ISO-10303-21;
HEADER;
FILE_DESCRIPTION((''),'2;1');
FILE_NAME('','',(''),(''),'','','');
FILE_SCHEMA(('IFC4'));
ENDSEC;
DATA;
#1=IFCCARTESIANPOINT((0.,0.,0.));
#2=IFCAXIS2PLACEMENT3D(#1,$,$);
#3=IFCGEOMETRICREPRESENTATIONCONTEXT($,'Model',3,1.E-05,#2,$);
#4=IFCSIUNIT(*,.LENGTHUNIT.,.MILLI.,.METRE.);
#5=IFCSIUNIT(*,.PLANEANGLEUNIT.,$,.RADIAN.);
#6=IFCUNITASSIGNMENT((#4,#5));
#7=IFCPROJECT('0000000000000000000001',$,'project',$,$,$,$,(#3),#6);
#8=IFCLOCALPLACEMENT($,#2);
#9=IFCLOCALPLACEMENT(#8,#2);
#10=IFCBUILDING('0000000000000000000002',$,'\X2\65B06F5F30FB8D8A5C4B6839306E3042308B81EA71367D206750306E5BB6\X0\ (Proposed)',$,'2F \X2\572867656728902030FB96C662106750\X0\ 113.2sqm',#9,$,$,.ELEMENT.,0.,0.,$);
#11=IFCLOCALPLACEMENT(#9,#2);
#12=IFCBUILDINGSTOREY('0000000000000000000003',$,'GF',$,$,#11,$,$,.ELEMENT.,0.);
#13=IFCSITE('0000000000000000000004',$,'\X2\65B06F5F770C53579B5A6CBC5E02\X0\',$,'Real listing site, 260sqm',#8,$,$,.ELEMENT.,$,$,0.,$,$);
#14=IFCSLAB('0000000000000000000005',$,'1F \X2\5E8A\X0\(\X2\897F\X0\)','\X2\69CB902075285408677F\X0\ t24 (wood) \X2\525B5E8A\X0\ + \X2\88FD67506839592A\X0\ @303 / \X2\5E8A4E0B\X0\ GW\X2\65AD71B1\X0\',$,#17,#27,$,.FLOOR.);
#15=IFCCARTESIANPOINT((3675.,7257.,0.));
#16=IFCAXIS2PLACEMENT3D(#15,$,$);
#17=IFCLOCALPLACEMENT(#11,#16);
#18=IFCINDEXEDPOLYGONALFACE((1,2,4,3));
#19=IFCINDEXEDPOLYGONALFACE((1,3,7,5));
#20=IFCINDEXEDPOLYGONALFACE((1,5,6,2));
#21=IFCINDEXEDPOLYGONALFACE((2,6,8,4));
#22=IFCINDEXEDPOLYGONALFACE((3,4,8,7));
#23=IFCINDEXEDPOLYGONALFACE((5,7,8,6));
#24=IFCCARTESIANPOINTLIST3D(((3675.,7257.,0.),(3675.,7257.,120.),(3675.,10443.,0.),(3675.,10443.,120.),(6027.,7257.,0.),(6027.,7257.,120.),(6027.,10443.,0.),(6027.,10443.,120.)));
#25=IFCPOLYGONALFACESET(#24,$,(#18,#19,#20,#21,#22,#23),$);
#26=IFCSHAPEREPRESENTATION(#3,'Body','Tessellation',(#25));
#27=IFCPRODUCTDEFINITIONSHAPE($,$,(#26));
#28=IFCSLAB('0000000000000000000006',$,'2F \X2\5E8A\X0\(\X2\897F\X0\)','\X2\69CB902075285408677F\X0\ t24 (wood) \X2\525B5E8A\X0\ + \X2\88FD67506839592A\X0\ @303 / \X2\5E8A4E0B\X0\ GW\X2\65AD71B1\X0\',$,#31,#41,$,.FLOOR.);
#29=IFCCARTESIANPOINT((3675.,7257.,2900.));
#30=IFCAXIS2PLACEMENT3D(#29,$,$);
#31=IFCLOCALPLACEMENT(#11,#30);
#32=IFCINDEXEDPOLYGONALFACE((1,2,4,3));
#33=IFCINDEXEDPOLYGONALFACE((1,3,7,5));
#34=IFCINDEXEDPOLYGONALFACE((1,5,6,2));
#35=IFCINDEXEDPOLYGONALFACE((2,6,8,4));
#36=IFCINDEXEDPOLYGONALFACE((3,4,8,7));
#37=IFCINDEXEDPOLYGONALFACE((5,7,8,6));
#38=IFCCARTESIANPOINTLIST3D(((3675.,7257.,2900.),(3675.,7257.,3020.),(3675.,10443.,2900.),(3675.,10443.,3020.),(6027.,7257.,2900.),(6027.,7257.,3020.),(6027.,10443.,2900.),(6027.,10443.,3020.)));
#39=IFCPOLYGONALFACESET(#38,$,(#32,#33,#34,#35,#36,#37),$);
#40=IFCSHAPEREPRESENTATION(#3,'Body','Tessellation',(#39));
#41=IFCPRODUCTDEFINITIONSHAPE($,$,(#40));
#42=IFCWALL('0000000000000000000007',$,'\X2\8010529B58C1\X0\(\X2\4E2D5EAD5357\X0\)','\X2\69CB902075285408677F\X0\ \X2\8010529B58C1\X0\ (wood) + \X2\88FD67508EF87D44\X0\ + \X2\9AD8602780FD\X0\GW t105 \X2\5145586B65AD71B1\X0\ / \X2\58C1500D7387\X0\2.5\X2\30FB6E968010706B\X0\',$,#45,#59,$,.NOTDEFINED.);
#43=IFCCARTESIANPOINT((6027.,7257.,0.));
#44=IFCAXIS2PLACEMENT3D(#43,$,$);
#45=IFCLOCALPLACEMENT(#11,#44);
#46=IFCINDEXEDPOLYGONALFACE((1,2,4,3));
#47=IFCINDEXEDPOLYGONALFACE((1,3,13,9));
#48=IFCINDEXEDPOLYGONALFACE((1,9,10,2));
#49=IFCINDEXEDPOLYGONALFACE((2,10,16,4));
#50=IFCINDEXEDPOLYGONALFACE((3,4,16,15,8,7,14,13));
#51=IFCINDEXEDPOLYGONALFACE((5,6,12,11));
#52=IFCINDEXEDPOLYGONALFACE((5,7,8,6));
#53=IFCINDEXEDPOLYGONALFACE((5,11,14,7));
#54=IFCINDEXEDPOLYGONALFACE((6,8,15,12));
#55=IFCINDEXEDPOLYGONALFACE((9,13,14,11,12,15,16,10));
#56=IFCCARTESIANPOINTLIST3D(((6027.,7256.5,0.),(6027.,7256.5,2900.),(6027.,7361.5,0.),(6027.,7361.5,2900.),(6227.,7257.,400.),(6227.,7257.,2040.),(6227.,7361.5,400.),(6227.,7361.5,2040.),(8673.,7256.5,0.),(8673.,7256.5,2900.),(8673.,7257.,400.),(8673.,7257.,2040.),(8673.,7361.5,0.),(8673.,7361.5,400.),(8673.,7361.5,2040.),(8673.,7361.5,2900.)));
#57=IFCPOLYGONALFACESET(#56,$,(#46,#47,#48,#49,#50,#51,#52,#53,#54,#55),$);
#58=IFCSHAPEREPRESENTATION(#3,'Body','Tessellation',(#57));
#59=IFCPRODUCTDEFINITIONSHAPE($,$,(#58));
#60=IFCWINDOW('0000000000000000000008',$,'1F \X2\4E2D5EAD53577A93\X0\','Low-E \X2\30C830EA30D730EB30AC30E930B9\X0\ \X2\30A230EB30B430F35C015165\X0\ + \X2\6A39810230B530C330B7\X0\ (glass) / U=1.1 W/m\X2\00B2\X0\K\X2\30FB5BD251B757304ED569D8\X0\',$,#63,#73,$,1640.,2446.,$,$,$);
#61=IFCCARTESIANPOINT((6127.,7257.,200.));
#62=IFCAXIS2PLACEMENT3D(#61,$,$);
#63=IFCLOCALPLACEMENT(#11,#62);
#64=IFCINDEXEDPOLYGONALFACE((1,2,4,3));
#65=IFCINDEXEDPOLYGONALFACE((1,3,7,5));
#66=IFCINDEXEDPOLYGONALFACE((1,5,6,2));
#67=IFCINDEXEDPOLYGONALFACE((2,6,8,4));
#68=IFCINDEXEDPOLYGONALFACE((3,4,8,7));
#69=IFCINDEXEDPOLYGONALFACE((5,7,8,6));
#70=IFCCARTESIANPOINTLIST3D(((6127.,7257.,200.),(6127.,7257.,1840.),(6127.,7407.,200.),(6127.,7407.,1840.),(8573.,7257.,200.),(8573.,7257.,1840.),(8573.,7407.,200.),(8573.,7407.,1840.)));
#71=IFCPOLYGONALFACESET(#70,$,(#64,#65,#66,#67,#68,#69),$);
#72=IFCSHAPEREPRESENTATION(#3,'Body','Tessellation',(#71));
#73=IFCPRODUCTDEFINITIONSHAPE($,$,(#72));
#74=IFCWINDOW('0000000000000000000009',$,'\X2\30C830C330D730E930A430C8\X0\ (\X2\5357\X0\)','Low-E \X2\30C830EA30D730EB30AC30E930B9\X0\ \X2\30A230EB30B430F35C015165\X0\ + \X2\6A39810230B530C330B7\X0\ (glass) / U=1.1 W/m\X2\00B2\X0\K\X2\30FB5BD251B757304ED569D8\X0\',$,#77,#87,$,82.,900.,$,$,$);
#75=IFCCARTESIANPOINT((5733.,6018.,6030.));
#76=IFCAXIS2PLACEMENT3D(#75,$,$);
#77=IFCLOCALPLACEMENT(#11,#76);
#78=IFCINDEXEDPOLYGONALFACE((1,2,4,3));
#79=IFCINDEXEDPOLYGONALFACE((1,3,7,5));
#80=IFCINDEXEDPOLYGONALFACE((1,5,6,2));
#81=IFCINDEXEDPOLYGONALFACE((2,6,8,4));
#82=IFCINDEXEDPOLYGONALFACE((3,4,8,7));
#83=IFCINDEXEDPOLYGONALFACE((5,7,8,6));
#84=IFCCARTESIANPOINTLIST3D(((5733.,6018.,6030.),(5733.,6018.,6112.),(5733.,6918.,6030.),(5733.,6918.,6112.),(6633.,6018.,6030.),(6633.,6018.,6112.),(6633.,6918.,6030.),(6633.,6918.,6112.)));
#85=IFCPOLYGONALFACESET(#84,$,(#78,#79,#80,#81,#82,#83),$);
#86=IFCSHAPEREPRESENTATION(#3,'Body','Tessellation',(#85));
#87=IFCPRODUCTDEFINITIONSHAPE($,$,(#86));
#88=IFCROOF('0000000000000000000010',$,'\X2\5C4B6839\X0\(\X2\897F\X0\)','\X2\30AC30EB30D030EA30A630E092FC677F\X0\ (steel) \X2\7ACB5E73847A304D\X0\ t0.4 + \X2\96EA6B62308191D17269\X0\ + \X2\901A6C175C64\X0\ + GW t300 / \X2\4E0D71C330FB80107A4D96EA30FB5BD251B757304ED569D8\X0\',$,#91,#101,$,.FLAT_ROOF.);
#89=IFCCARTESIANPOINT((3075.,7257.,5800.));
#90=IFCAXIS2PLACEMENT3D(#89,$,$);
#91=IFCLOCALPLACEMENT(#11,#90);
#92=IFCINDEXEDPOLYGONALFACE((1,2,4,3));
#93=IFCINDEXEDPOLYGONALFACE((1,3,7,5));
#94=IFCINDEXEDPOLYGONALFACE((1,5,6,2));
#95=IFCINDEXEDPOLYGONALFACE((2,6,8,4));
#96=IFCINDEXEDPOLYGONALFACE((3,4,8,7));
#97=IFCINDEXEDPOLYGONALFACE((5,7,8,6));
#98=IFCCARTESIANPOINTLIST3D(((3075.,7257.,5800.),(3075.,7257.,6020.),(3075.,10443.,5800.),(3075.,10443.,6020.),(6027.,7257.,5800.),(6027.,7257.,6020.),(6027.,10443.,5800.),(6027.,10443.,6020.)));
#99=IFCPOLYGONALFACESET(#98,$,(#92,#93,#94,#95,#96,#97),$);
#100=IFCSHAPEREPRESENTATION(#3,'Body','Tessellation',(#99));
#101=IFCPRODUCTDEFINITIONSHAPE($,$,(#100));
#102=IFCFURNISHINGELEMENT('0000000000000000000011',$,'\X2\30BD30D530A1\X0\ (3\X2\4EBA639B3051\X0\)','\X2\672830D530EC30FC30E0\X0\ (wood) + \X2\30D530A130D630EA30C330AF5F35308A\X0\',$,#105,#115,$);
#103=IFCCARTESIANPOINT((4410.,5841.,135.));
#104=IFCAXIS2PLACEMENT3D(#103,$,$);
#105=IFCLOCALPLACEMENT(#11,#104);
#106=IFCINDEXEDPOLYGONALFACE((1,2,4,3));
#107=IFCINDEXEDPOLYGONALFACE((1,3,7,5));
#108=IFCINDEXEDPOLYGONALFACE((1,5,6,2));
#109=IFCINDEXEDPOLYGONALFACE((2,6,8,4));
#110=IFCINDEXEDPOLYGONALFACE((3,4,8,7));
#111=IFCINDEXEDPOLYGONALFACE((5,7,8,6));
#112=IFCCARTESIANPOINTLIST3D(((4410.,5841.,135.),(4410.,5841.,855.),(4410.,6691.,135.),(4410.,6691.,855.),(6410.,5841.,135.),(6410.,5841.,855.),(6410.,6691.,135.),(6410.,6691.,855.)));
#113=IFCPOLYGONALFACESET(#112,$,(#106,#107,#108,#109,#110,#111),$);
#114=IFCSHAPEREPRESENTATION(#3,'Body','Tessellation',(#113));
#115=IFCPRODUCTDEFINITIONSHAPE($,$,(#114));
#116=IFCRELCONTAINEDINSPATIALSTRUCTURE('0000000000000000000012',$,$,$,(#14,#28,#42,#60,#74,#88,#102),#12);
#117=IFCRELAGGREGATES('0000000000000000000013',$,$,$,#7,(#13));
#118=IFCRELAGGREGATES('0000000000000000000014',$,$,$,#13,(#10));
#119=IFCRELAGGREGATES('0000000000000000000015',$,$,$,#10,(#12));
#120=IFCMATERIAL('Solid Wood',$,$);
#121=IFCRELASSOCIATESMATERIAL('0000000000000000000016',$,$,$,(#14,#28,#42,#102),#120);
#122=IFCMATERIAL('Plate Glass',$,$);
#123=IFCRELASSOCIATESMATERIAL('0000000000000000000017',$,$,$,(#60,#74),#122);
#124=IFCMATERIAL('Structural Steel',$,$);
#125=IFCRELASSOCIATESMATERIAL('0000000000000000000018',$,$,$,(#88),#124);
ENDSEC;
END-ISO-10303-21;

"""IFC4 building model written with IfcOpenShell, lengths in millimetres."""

from ifc_helpers import new_model, si_unit, frame, frame_2d, origin, place, context, project, spatial, rectangle, extrude, material, element, fill, save


model = new_model("IFC4")

# Units and contexts
model_context = context("Model", 3, precision=1e-05, world=origin())
ifc_project = project(units=[si_unit("LENGTHUNIT", "METRE", prefix="MILLI"), si_unit("PLANEANGLEUNIT", "RADIAN")], contexts=[model_context])

# Site, building, storey
site_placement = place(None, origin())
site = spatial("IfcSite", under=ifc_project, at=site_placement, Name="新潟県南魚沼市", ObjectType="Real listing site, 260sqm", CompositionType="ELEMENT", RefElevation=0.0)
building_placement = place(site_placement, origin())
building = spatial("IfcBuilding", under=site, at=building_placement, Name="新潟・越屋根のある自然素材の家 (Proposed)", ObjectType="2F 在来木造・集成材 113.2sqm", CompositionType="ELEMENT", ElevationOfRefHeight=0.0, ElevationOfTerrain=0.0)
storey_placement = place(building_placement, origin())
storey = spatial("IfcBuildingStorey", under=building, at=storey_placement, Name="GF", CompositionType="ELEMENT", Elevation=0.0)

# Shared definitions
ifc_material_1 = material(Name="Solid Wood")

# Slabs
slab_1_placement = place(storey_placement, frame((3675.0, 7257.0, 0.0)))
element("IfcSlab", 1, at=slab_1_placement, inside=storey, material=ifc_material_1, Name="1F 床(西)", Description="構造用合板 t24 (wood) 剛床 + 製材根太 @303 / 床下 GW断熱", PredefinedType="FLOOR", context=model_context, shape_type="SweptSolid", body=[
    extrude(rectangle(XDim=2352.0, YDim=3186.0, at=frame_2d((1176.0, 1593.0))), frame((3675.0, 7257.0, 0.0)), (0.0, 0.0, 1.0), 120.0),
])
slab_2_placement = place(storey_placement, frame((3675.0, 7257.0, 2900.0)))
element("IfcSlab", 2, at=slab_2_placement, inside=storey, material=ifc_material_1, Name="2F 床(西)", Description="構造用合板 t24 (wood) 剛床 + 製材根太 @303 / 床下 GW断熱", PredefinedType="FLOOR", context=model_context, shape_type="SweptSolid", body=[
    extrude(rectangle(XDim=2352.0, YDim=3186.0, at=frame_2d((1176.0, 1593.0))), frame((3675.0, 7257.0, 2900.0)), (0.0, 0.0, 1.0), 120.0),
])

# Wall, opening, window
wall_1_placement = place(storey_placement, frame((6027.0, 7257.0, 0.0)))
wall_1 = element("IfcWall", 3, at=wall_1_placement, inside=storey, material=ifc_material_1, Name="耐力壁(中庭南)", Description="構造用合板 耐力壁 (wood) + 製材軸組 + 高性能GW t105 充填断熱 / 壁倍率2.5・準耐火", PredefinedType="NOTDEFINED", context=model_context, shape_type="SweptSolid", body=[
    extrude(rectangle(XDim=2646.0, YDim=105.0, at=frame_2d((1323.0, 52.0))), frame((6027.0, 7257.0, 0.0)), (0.0, 0.0, 1.0), 2900.0),
])
opening_placement = place(storey_placement, frame((6127.0, 7257.0, 200.0)))
opening = element("IfcOpeningElement", 4, at=opening_placement, cuts=wall_1, PredefinedType="NOTDEFINED", context=model_context, shape_type="SweptSolid", body=[
    extrude(rectangle(XDim=2446.0, YDim=150.0, at=frame_2d((1223.0, 75.0))), frame((6127.0, 7257.0, 200.0)), (0.0, 0.0, 1.0), 1640.0),
])
ifc_material_2 = material(Name="Plate Glass")
window_1_placement = place(storey_placement, frame((6127.0, 7257.0, 200.0)))
window_1 = element("IfcWindow", 5, at=window_1_placement, inside=storey, material=ifc_material_2, Name="1F 中庭南窓", Description="Low-E トリプルガラス アルゴン封入 + 樹脂サッシ (glass) / U=1.1 W/m²K・寒冷地仕様", OverallHeight=1640.0, OverallWidth=2446.0, context=model_context, shape_type="SweptSolid", body=[
    extrude(rectangle(XDim=2446.0, YDim=150.0, at=frame_2d((1223.0, 75.0))), frame((6127.0, 7257.0, 200.0)), (0.0, 0.0, 1.0), 1640.0),
])
fill(opening, window_1)

# Window
window_2_placement = place(storey_placement, frame((5733.0, 6018.0, 6030.0)))
element("IfcWindow", 6, at=window_2_placement, inside=storey, material=ifc_material_2, Name="トップライト (南)", Description="Low-E トリプルガラス アルゴン封入 + 樹脂サッシ (glass) / U=1.1 W/m²K・寒冷地仕様", OverallHeight=82.0, OverallWidth=900.0, context=model_context, shape_type="SweptSolid", body=[
    extrude(rectangle(XDim=900.0, YDim=900.0, at=frame_2d((450.0, 450.0))), frame((5733.0, 6018.0, 6030.0)), (0.0, 0.0, 1.0), 82.0),
])

# Roof
ifc_material_3 = material(Name="Structural Steel")
for number, where, name in (
    (7, (3075.0, 7257.0, 5800.0), "屋根(西)"),
):
    element("IfcRoof", number, at=place(storey_placement, frame(where)), inside=storey, material=ifc_material_3, Name=name, Description="ガルバリウム鋼板 (steel) 立平葺き t0.4 + 雪止め金物 + 通気層 + GW t300 / 不燃・耐積雪・寒冷地仕様", PredefinedType="FLAT_ROOF", context=model_context, shape_type="SweptSolid", body=[
        extrude(rectangle(XDim=2952.0, YDim=3186.0, at=frame_2d((1476.0, 1593.0))), frame((3075.0, 7257.0, 5800.0)), (0.0, 0.0, 1.0), 220.0),
    ])

# Furnishing element
furnishing_placement = place(storey_placement, frame((4410.0, 5841.0, 135.0)))
element("IfcFurnishingElement", 8, at=furnishing_placement, inside=storey, material=ifc_material_1, Name="ソファ (3人掛け)", Description="木フレーム (wood) + ファブリック張り", context=model_context, shape_type="SweptSolid", body=[
    extrude(rectangle(XDim=2000.0, YDim=850.0, at=frame_2d((1000.0, 425.0))), frame((4410.0, 5841.0, 135.0)), (0.0, 0.0, 1.0), 720.0),
])

save(model, "model.ifc")
